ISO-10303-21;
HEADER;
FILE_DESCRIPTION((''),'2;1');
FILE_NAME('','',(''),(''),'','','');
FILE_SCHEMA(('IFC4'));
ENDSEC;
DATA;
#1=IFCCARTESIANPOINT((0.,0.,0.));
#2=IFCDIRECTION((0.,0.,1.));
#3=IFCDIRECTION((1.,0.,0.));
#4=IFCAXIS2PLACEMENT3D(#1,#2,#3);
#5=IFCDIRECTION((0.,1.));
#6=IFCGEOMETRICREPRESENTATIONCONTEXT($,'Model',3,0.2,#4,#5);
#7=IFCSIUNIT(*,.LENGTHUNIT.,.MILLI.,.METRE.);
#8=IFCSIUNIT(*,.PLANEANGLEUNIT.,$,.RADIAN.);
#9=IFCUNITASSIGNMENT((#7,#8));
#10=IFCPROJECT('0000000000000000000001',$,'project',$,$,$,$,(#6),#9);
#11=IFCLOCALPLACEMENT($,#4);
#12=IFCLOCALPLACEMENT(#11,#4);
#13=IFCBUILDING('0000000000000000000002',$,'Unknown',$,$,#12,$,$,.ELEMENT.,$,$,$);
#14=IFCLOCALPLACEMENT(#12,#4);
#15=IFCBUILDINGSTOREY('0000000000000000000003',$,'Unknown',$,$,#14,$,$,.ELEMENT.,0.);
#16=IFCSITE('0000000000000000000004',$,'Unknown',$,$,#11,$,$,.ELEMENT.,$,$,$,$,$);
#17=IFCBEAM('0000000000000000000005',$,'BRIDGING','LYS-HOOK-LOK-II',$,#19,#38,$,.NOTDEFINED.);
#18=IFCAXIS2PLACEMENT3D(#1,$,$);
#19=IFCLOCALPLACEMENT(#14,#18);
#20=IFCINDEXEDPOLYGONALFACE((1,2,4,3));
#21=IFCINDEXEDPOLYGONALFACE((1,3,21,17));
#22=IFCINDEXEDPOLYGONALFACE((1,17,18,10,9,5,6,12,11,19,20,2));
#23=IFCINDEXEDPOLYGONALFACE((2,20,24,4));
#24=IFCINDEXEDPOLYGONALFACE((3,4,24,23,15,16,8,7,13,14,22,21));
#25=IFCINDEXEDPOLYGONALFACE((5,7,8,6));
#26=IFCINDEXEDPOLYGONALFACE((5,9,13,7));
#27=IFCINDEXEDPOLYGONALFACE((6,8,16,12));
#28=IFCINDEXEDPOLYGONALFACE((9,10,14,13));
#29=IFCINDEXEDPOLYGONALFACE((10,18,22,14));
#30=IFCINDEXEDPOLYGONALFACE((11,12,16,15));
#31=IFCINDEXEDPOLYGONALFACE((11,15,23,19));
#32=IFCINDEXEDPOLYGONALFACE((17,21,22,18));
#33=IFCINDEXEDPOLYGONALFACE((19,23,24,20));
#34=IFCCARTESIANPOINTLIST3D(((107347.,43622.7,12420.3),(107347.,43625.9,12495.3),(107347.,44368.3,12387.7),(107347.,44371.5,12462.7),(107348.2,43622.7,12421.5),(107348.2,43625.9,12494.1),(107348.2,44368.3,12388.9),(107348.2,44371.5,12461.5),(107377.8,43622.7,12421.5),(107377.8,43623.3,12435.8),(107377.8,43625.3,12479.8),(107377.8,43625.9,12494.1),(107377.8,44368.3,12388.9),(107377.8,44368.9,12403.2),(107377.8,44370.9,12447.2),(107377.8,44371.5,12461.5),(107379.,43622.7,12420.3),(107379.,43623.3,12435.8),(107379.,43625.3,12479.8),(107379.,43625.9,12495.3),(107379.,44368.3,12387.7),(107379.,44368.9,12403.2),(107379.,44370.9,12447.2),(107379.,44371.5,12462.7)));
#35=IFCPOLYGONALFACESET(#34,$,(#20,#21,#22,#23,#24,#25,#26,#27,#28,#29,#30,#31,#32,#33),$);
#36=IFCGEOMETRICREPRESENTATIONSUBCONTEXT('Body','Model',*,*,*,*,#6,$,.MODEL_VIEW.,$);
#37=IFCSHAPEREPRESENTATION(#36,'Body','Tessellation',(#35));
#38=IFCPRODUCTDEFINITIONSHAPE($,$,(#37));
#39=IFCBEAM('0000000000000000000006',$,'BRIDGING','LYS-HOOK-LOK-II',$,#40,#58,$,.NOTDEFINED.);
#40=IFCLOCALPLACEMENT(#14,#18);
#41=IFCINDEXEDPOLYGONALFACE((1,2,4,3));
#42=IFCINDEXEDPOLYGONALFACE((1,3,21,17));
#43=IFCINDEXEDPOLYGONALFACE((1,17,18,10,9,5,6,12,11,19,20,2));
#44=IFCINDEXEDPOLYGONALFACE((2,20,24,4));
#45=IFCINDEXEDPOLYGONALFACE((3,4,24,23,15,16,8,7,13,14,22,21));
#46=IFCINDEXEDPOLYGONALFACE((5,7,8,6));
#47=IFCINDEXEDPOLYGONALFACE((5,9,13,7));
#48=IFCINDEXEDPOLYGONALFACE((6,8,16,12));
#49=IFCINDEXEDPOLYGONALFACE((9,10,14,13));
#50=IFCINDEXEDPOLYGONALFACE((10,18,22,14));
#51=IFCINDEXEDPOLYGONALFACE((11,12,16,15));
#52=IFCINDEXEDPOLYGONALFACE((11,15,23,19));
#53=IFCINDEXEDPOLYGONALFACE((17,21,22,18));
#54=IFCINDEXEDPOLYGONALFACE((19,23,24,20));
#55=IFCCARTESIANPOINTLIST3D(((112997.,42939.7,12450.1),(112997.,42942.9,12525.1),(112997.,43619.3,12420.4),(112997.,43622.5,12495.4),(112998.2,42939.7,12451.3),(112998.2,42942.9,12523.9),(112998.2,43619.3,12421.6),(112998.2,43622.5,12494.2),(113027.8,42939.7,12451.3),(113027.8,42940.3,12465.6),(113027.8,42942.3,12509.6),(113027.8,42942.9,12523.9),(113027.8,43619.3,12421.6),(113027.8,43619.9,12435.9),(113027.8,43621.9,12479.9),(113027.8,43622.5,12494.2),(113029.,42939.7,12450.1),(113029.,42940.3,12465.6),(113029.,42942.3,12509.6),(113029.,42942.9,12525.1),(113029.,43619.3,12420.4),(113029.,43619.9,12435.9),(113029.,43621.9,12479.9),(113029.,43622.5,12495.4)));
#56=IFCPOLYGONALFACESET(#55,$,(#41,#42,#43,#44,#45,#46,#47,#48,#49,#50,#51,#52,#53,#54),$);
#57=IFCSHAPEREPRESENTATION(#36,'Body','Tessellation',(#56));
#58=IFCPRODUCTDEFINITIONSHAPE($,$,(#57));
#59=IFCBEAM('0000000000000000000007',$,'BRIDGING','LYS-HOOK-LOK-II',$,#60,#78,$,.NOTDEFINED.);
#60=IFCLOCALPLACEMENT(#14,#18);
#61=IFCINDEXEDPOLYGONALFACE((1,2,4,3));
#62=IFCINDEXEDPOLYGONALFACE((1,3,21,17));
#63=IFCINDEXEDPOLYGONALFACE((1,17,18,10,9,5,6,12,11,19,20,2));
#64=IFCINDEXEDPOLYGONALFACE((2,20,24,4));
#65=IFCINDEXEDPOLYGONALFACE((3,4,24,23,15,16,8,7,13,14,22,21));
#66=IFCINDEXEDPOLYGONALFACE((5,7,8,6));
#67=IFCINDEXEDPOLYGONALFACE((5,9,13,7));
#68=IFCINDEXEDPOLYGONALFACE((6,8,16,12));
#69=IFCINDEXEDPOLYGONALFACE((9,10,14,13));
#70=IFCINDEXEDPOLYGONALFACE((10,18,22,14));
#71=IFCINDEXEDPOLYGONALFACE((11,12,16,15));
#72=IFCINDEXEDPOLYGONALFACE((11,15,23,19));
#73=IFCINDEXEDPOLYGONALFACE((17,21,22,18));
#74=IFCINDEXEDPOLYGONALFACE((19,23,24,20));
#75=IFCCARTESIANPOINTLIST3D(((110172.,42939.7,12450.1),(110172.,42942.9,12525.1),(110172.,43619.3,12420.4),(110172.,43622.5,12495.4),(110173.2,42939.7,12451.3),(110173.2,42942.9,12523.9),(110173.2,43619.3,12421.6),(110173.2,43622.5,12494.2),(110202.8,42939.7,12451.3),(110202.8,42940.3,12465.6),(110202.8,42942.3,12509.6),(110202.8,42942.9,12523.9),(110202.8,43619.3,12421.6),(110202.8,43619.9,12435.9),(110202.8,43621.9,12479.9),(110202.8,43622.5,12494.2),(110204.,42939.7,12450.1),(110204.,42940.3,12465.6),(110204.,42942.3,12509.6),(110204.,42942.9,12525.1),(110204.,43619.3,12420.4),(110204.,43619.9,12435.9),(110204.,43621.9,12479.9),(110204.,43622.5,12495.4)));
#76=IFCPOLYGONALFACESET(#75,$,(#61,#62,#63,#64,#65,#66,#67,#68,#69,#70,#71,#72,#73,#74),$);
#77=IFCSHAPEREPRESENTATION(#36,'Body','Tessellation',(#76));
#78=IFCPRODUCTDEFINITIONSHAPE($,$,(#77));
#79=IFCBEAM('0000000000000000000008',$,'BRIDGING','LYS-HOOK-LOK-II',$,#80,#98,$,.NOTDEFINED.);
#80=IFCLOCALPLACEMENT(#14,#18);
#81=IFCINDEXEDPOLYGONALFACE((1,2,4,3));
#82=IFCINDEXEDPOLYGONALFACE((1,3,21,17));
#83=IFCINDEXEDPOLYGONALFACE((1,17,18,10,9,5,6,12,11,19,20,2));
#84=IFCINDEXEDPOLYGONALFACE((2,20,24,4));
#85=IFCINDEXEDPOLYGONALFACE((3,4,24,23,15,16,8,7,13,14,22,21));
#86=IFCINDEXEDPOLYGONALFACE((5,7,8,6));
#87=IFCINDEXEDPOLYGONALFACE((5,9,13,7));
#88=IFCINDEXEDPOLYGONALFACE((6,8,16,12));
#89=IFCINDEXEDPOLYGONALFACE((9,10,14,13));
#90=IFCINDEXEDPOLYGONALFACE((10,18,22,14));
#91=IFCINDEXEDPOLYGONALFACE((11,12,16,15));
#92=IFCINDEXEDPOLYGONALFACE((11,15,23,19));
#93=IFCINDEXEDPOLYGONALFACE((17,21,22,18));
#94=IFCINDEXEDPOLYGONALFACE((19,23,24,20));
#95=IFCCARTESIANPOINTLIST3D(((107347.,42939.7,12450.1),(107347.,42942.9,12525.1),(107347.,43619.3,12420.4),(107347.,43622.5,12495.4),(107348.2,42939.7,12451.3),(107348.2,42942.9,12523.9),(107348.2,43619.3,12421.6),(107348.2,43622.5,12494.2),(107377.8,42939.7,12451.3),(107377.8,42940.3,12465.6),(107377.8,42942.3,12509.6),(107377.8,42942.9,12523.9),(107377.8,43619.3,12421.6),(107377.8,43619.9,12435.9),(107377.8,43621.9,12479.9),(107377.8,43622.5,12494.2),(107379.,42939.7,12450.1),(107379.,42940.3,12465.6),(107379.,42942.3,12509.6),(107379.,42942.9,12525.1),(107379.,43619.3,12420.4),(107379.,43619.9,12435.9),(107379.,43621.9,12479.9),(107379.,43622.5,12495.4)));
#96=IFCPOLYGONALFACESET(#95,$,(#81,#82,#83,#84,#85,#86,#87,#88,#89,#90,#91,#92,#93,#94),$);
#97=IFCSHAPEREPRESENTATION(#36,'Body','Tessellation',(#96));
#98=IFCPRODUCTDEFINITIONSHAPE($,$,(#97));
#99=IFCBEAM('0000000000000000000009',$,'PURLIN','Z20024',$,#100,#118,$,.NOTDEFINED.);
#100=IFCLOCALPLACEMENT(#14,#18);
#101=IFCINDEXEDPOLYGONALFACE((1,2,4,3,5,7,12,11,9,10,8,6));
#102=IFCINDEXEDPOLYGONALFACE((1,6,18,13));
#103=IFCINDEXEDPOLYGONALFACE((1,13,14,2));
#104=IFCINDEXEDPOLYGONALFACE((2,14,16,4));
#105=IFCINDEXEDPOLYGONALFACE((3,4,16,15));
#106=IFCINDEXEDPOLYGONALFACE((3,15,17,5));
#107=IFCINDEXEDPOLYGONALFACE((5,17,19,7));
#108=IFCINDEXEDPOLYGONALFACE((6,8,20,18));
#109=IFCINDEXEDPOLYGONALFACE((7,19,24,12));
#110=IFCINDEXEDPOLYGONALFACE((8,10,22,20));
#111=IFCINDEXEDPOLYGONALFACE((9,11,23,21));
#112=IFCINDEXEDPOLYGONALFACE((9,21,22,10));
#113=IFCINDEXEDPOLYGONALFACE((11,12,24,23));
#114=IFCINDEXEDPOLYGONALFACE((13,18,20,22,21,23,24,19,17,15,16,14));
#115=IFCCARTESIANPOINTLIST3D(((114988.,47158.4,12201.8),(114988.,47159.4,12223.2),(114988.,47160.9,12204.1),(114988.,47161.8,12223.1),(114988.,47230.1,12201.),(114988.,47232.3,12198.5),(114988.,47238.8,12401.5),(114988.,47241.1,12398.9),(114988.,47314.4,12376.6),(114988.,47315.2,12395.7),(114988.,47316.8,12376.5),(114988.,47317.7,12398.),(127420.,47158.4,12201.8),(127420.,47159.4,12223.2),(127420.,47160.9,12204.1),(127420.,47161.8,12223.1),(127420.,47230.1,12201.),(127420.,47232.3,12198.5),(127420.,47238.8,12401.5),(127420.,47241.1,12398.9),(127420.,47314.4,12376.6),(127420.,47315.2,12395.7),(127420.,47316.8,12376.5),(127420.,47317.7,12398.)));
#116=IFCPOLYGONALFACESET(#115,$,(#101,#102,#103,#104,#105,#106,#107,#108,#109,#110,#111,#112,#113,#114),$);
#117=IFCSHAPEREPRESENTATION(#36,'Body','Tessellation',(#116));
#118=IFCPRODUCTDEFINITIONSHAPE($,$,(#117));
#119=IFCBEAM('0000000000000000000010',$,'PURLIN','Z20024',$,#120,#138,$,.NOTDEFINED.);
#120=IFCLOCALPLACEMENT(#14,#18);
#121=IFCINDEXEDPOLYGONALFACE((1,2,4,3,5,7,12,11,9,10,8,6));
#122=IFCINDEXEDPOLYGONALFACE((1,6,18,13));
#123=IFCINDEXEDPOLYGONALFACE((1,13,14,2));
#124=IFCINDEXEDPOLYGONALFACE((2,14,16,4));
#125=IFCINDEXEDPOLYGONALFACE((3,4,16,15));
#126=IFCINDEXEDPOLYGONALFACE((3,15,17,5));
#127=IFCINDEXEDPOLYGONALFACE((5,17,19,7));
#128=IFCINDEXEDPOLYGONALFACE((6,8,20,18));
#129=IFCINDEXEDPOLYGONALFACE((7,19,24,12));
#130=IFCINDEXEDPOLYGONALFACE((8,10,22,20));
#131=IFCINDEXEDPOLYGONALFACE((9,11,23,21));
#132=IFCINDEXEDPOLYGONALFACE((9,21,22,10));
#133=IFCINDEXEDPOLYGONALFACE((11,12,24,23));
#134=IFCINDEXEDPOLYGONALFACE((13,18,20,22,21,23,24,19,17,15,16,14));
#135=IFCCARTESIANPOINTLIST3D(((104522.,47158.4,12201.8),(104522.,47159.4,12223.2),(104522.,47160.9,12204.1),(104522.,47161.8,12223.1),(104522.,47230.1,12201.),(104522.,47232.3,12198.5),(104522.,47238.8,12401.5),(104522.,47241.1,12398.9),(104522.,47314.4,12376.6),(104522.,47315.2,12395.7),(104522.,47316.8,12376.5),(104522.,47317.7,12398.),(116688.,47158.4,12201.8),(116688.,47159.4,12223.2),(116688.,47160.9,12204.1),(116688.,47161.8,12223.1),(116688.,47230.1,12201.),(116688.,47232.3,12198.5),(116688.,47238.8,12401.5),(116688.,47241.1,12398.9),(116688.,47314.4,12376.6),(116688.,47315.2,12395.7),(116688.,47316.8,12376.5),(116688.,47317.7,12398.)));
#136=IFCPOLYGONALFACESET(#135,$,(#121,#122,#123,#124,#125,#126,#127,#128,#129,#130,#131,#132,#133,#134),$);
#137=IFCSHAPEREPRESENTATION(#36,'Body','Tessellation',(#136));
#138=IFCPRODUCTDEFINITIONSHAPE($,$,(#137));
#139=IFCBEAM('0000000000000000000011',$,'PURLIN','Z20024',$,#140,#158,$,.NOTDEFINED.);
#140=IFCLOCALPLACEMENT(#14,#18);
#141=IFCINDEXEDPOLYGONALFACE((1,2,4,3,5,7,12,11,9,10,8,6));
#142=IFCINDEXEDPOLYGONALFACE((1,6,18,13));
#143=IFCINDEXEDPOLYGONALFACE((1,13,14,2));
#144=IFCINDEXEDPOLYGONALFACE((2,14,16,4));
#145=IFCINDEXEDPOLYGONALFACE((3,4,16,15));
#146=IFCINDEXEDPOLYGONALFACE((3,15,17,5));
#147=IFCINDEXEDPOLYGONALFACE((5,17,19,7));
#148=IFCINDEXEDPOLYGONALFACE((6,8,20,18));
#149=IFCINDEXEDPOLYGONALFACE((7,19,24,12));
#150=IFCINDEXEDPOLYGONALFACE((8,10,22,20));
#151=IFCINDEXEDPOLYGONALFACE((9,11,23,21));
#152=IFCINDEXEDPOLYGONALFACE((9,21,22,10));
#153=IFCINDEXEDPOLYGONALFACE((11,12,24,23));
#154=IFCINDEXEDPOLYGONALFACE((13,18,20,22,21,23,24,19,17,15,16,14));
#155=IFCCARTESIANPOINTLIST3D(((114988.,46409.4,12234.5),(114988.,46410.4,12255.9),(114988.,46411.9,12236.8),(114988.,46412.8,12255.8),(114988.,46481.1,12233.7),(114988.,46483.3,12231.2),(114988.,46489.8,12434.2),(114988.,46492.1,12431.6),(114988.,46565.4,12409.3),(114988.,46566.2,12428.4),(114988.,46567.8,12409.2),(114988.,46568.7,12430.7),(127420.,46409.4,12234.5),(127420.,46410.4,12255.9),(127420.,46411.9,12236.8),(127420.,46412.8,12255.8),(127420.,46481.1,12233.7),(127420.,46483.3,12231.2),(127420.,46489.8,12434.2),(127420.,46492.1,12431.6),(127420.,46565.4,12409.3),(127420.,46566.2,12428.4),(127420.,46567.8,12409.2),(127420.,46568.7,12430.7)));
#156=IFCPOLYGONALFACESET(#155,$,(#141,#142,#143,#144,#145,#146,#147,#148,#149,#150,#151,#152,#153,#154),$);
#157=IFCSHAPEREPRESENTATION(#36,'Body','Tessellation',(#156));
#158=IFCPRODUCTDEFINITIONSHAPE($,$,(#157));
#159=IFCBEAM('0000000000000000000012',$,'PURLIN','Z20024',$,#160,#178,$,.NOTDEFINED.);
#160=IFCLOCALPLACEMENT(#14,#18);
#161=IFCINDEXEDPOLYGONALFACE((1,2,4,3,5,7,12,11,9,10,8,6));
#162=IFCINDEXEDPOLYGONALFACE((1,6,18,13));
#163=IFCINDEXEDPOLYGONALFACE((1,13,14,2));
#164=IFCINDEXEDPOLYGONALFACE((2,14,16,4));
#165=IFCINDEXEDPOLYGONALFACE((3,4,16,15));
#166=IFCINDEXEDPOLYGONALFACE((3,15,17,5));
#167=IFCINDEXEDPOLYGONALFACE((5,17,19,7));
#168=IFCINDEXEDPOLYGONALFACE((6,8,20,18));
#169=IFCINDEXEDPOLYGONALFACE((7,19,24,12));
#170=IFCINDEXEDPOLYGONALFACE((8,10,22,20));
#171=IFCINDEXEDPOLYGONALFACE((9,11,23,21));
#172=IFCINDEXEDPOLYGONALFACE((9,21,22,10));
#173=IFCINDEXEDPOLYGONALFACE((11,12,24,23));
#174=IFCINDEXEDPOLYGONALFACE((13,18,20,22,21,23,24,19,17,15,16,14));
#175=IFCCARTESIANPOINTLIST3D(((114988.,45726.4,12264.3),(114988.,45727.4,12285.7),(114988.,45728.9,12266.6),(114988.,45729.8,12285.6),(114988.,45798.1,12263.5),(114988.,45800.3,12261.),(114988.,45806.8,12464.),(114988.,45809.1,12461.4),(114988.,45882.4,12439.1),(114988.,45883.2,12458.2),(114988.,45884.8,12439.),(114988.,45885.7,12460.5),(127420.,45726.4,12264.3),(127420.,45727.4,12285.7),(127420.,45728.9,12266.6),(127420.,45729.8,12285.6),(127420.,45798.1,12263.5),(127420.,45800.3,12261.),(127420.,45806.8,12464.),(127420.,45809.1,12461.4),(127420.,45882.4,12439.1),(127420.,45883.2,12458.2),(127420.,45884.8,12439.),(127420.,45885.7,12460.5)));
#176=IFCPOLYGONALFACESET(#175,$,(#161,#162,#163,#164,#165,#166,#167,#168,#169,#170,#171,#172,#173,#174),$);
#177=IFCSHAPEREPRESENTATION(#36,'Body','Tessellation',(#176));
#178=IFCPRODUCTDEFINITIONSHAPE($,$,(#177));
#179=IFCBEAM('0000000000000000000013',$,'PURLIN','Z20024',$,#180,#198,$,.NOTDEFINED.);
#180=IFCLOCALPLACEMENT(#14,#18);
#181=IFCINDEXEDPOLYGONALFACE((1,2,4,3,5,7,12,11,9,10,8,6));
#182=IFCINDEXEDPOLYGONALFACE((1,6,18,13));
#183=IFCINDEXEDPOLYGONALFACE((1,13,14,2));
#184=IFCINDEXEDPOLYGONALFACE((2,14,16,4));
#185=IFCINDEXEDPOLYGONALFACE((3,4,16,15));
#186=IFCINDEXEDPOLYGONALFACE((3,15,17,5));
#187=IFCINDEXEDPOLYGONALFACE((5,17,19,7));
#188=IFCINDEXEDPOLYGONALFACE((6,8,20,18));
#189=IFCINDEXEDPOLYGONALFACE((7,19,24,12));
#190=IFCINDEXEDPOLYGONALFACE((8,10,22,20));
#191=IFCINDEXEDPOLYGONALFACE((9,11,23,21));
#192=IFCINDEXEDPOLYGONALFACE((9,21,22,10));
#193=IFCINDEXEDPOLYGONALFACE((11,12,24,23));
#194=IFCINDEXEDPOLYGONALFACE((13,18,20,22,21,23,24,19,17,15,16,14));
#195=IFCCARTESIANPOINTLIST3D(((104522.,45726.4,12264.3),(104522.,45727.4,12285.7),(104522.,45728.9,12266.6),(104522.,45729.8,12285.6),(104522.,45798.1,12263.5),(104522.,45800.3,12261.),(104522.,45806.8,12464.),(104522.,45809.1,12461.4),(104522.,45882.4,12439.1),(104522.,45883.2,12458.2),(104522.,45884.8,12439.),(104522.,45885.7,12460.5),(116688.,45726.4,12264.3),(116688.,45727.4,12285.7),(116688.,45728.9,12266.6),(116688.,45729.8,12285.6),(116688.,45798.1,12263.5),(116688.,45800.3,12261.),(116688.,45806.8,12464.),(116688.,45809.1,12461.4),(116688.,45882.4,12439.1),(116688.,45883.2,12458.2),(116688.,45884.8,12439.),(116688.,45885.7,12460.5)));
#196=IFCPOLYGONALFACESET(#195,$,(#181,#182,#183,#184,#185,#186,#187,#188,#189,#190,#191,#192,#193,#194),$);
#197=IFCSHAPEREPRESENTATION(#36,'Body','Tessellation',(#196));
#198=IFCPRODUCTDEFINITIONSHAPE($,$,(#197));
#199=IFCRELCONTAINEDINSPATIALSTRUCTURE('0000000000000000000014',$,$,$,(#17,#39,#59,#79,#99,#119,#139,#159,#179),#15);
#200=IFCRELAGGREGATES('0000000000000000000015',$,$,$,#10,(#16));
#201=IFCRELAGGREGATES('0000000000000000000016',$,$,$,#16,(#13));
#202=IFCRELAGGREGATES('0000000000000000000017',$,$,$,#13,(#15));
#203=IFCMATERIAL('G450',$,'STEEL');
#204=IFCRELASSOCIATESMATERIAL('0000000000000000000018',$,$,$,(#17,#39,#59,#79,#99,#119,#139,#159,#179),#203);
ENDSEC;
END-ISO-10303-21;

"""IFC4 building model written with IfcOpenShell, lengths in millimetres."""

from ifc_helpers import new_model, si_unit, direction, frame, origin_with_axes, place, context, subcontext, project, spatial, line, indexed_curve, outline, extrude, material, element, save


model = new_model("IFC4")

# Units and contexts
model_context = context("Model", 3, precision=0.2, world=origin_with_axes(), true_north=direction((0.0, 1.0)))
body_context = subcontext(model_context, "Body", "Model", "MODEL_VIEW")
ifc_project = project(units=[si_unit("LENGTHUNIT", "METRE", prefix="MILLI"), si_unit("PLANEANGLEUNIT", "RADIAN")], contexts=[model_context])

# Site, building, storey
site_placement = place(None, origin_with_axes())
site = spatial("IfcSite", under=ifc_project, at=site_placement, Name="Unknown", CompositionType="ELEMENT")
building_placement = place(site_placement, origin_with_axes())
building = spatial("IfcBuilding", under=site, at=building_placement, Name="Unknown", CompositionType="ELEMENT")
storey_placement = place(building_placement, origin_with_axes())
storey = spatial("IfcBuildingStorey", under=building, at=storey_placement, Name="Unknown", CompositionType="ELEMENT", Elevation=0.0)

# Beams
ifc_material_1 = material(Name="G450", Category="STEEL")
for number, where, z_axis, x_axis, name in (
    (1, (107363.0, 43624.3, 12457.8), (1.0, 0.0, 0.0), (0.0, 0.999046, -0.043681), "BRIDGING"),
):
    element("IfcBeam", number, at=place(storey_placement, frame(where, z_axis=z_axis, x_axis=x_axis)), inside=storey, material=ifc_material_1, Name=name, Description="LYS-HOOK-LOK-II", PredefinedType="NOTDEFINED", context=body_context, shape_type="SolidModel", body=[
        extrude(outline(indexed_curve([(16.0, -37.5), (16.0, -22.0), (14.8, -22.0), (14.8, -36.3), (-14.8, -36.3), (-14.8, 36.3), (14.8, 36.3), (14.8, 22.0), (16.0, 22.0), (16.0, 37.5), (-16.0, 37.5), (-16.0, -37.5)], segments=[line(1, 2, 3, 4, 5, 6, 7, 8, 9, 10, 11, 12, 1)])), frame((0.0, 0.0, 0.0), z_axis=(-1.0, 0.0, 0.0), x_axis=(0.0, 0.0, 1.0)), (0.0, 0.0, -1.0), 746.3),
    ])
for number, where, z_axis, x_axis, name in (
    (2, (113013.0, 42941.3, 12487.6), (1.0, 0.0, 0.0), (0.0, 0.999046, -0.043661), "BRIDGING"),
    (3, (110188.0, 42941.3, 12487.6), (1.0, 0.0, 0.0), (0.0, 0.999046, -0.043661), "BRIDGING"),
    (4, (107363.0, 42941.3, 12487.6), (1.0, 0.0, 0.0), (0.0, 0.999046, -0.043661), "BRIDGING"),
):
    element("IfcBeam", number, at=place(storey_placement, frame(where, z_axis=z_axis, x_axis=x_axis)), inside=storey, material=ifc_material_1, Name=name, Description="LYS-HOOK-LOK-II", PredefinedType="NOTDEFINED", context=body_context, shape_type="SolidModel", body=[
        extrude(outline(indexed_curve([(16.0, -37.5), (16.0, -22.0), (14.8, -22.0), (14.8, -36.3), (-14.8, -36.3), (-14.8, 36.3), (14.8, 36.3), (14.8, 22.0), (16.0, 22.0), (16.0, 37.5), (-16.0, 37.5), (-16.0, -37.5)], segments=[line(1, 2, 3, 4, 5, 6, 7, 8, 9, 10, 11, 12, 1)])), frame((0.0, 0.0, 0.0), z_axis=(-1.0, 0.0, 0.0), x_axis=(0.0, 0.0, 1.0)), (0.0, 0.0, -1.0), 680.2),
    ])
beam_1_placement = place(storey_placement, frame((114988.0, 47235.6, 12300.0), z_axis=(0.0, -0.999048, 0.043619), x_axis=(1.0, 0.0, 0.0)))
element("IfcBeam", 5, at=beam_1_placement, inside=storey, material=ifc_material_1, Name="PURLIN", Description="Z20024", PredefinedType="NOTDEFINED", context=body_context, shape_type="SolidModel", body=[
    extrude(outline(indexed_curve([(72.8, -101.5), (72.8, -80.0), (70.4, -80.0), (70.4, -99.1), (1.2, -99.1), (1.2, 101.5), (-77.8, 101.5), (-77.8, 80.0), (-75.4, 80.0), (-75.4, 99.1), (-1.2, 99.1), (-1.2, -101.5)], segments=[line(1, 2, 3, 4, 5, 6, 7, 8, 9, 10, 11, 12, 1)])), frame((0.0, 0.0, 0.0), z_axis=(-1.0, 0.0, 0.0), x_axis=(0.0, 0.0, 1.0)), (0.0, 0.0, -1.0), 12432.0),
])
beam_2_placement = place(storey_placement, frame((104522.0, 47235.6, 12300.0), z_axis=(0.0, -0.999048, 0.043619), x_axis=(1.0, 0.0, 0.0)))
element("IfcBeam", 6, at=beam_2_placement, inside=storey, material=ifc_material_1, Name="PURLIN", Description="Z20024", PredefinedType="NOTDEFINED", context=body_context, shape_type="SolidModel", body=[
    extrude(outline(indexed_curve([(72.8, -101.5), (72.8, -80.0), (70.4, -80.0), (70.4, -99.1), (1.2, -99.1), (1.2, 101.5), (-77.8, 101.5), (-77.8, 80.0), (-75.4, 80.0), (-75.4, 99.1), (-1.2, 99.1), (-1.2, -101.5)], segments=[line(1, 2, 3, 4, 5, 6, 7, 8, 9, 10, 11, 12, 1)])), frame((0.0, 0.0, 0.0), z_axis=(-1.0, 0.0, 0.0), x_axis=(0.0, 0.0, 1.0)), (0.0, 0.0, -1.0), 12166.0),
])
for number, where, z_axis, x_axis, name in (
    (7, (114988.0, 46486.6, 12332.7), (0.0, -0.999048, 0.043619), (1.0, 0.0, 0.0), "PURLIN"),
    (8, (114988.0, 45803.6, 12362.5), (0.0, -0.999048, 0.043619), (1.0, 0.0, 0.0), "PURLIN"),
):
    element("IfcBeam", number, at=place(storey_placement, frame(where, z_axis=z_axis, x_axis=x_axis)), inside=storey, material=ifc_material_1, Name=name, Description="Z20024", PredefinedType="NOTDEFINED", context=body_context, shape_type="SolidModel", body=[
        extrude(outline(indexed_curve([(72.8, -101.5), (72.8, -80.0), (70.4, -80.0), (70.4, -99.1), (1.2, -99.1), (1.2, 101.5), (-77.8, 101.5), (-77.8, 80.0), (-75.4, 80.0), (-75.4, 99.1), (-1.2, 99.1), (-1.2, -101.5)], segments=[line(1, 2, 3, 4, 5, 6, 7, 8, 9, 10, 11, 12, 1)])), frame((0.0, 0.0, 0.0), z_axis=(-1.0, 0.0, 0.0), x_axis=(0.0, 0.0, 1.0)), (0.0, 0.0, -1.0), 12432.0),
    ])
beam_3_placement = place(storey_placement, frame((104522.0, 45803.6, 12362.5), z_axis=(0.0, -0.999048, 0.043619), x_axis=(1.0, 0.0, 0.0)))
element("IfcBeam", 9, at=beam_3_placement, inside=storey, material=ifc_material_1, Name="PURLIN", Description="Z20024", PredefinedType="NOTDEFINED", context=body_context, shape_type="SolidModel", body=[
    extrude(outline(indexed_curve([(72.8, -101.5), (72.8, -80.0), (70.4, -80.0), (70.4, -99.1), (1.2, -99.1), (1.2, 101.5), (-77.8, 101.5), (-77.8, 80.0), (-75.4, 80.0), (-75.4, 99.1), (-1.2, 99.1), (-1.2, -101.5)], segments=[line(1, 2, 3, 4, 5, 6, 7, 8, 9, 10, 11, 12, 1)])), frame((0.0, 0.0, 0.0), z_axis=(-1.0, 0.0, 0.0), x_axis=(0.0, 0.0, 1.0)), (0.0, 0.0, -1.0), 12166.0),
])

save(model, "model.ifc")
